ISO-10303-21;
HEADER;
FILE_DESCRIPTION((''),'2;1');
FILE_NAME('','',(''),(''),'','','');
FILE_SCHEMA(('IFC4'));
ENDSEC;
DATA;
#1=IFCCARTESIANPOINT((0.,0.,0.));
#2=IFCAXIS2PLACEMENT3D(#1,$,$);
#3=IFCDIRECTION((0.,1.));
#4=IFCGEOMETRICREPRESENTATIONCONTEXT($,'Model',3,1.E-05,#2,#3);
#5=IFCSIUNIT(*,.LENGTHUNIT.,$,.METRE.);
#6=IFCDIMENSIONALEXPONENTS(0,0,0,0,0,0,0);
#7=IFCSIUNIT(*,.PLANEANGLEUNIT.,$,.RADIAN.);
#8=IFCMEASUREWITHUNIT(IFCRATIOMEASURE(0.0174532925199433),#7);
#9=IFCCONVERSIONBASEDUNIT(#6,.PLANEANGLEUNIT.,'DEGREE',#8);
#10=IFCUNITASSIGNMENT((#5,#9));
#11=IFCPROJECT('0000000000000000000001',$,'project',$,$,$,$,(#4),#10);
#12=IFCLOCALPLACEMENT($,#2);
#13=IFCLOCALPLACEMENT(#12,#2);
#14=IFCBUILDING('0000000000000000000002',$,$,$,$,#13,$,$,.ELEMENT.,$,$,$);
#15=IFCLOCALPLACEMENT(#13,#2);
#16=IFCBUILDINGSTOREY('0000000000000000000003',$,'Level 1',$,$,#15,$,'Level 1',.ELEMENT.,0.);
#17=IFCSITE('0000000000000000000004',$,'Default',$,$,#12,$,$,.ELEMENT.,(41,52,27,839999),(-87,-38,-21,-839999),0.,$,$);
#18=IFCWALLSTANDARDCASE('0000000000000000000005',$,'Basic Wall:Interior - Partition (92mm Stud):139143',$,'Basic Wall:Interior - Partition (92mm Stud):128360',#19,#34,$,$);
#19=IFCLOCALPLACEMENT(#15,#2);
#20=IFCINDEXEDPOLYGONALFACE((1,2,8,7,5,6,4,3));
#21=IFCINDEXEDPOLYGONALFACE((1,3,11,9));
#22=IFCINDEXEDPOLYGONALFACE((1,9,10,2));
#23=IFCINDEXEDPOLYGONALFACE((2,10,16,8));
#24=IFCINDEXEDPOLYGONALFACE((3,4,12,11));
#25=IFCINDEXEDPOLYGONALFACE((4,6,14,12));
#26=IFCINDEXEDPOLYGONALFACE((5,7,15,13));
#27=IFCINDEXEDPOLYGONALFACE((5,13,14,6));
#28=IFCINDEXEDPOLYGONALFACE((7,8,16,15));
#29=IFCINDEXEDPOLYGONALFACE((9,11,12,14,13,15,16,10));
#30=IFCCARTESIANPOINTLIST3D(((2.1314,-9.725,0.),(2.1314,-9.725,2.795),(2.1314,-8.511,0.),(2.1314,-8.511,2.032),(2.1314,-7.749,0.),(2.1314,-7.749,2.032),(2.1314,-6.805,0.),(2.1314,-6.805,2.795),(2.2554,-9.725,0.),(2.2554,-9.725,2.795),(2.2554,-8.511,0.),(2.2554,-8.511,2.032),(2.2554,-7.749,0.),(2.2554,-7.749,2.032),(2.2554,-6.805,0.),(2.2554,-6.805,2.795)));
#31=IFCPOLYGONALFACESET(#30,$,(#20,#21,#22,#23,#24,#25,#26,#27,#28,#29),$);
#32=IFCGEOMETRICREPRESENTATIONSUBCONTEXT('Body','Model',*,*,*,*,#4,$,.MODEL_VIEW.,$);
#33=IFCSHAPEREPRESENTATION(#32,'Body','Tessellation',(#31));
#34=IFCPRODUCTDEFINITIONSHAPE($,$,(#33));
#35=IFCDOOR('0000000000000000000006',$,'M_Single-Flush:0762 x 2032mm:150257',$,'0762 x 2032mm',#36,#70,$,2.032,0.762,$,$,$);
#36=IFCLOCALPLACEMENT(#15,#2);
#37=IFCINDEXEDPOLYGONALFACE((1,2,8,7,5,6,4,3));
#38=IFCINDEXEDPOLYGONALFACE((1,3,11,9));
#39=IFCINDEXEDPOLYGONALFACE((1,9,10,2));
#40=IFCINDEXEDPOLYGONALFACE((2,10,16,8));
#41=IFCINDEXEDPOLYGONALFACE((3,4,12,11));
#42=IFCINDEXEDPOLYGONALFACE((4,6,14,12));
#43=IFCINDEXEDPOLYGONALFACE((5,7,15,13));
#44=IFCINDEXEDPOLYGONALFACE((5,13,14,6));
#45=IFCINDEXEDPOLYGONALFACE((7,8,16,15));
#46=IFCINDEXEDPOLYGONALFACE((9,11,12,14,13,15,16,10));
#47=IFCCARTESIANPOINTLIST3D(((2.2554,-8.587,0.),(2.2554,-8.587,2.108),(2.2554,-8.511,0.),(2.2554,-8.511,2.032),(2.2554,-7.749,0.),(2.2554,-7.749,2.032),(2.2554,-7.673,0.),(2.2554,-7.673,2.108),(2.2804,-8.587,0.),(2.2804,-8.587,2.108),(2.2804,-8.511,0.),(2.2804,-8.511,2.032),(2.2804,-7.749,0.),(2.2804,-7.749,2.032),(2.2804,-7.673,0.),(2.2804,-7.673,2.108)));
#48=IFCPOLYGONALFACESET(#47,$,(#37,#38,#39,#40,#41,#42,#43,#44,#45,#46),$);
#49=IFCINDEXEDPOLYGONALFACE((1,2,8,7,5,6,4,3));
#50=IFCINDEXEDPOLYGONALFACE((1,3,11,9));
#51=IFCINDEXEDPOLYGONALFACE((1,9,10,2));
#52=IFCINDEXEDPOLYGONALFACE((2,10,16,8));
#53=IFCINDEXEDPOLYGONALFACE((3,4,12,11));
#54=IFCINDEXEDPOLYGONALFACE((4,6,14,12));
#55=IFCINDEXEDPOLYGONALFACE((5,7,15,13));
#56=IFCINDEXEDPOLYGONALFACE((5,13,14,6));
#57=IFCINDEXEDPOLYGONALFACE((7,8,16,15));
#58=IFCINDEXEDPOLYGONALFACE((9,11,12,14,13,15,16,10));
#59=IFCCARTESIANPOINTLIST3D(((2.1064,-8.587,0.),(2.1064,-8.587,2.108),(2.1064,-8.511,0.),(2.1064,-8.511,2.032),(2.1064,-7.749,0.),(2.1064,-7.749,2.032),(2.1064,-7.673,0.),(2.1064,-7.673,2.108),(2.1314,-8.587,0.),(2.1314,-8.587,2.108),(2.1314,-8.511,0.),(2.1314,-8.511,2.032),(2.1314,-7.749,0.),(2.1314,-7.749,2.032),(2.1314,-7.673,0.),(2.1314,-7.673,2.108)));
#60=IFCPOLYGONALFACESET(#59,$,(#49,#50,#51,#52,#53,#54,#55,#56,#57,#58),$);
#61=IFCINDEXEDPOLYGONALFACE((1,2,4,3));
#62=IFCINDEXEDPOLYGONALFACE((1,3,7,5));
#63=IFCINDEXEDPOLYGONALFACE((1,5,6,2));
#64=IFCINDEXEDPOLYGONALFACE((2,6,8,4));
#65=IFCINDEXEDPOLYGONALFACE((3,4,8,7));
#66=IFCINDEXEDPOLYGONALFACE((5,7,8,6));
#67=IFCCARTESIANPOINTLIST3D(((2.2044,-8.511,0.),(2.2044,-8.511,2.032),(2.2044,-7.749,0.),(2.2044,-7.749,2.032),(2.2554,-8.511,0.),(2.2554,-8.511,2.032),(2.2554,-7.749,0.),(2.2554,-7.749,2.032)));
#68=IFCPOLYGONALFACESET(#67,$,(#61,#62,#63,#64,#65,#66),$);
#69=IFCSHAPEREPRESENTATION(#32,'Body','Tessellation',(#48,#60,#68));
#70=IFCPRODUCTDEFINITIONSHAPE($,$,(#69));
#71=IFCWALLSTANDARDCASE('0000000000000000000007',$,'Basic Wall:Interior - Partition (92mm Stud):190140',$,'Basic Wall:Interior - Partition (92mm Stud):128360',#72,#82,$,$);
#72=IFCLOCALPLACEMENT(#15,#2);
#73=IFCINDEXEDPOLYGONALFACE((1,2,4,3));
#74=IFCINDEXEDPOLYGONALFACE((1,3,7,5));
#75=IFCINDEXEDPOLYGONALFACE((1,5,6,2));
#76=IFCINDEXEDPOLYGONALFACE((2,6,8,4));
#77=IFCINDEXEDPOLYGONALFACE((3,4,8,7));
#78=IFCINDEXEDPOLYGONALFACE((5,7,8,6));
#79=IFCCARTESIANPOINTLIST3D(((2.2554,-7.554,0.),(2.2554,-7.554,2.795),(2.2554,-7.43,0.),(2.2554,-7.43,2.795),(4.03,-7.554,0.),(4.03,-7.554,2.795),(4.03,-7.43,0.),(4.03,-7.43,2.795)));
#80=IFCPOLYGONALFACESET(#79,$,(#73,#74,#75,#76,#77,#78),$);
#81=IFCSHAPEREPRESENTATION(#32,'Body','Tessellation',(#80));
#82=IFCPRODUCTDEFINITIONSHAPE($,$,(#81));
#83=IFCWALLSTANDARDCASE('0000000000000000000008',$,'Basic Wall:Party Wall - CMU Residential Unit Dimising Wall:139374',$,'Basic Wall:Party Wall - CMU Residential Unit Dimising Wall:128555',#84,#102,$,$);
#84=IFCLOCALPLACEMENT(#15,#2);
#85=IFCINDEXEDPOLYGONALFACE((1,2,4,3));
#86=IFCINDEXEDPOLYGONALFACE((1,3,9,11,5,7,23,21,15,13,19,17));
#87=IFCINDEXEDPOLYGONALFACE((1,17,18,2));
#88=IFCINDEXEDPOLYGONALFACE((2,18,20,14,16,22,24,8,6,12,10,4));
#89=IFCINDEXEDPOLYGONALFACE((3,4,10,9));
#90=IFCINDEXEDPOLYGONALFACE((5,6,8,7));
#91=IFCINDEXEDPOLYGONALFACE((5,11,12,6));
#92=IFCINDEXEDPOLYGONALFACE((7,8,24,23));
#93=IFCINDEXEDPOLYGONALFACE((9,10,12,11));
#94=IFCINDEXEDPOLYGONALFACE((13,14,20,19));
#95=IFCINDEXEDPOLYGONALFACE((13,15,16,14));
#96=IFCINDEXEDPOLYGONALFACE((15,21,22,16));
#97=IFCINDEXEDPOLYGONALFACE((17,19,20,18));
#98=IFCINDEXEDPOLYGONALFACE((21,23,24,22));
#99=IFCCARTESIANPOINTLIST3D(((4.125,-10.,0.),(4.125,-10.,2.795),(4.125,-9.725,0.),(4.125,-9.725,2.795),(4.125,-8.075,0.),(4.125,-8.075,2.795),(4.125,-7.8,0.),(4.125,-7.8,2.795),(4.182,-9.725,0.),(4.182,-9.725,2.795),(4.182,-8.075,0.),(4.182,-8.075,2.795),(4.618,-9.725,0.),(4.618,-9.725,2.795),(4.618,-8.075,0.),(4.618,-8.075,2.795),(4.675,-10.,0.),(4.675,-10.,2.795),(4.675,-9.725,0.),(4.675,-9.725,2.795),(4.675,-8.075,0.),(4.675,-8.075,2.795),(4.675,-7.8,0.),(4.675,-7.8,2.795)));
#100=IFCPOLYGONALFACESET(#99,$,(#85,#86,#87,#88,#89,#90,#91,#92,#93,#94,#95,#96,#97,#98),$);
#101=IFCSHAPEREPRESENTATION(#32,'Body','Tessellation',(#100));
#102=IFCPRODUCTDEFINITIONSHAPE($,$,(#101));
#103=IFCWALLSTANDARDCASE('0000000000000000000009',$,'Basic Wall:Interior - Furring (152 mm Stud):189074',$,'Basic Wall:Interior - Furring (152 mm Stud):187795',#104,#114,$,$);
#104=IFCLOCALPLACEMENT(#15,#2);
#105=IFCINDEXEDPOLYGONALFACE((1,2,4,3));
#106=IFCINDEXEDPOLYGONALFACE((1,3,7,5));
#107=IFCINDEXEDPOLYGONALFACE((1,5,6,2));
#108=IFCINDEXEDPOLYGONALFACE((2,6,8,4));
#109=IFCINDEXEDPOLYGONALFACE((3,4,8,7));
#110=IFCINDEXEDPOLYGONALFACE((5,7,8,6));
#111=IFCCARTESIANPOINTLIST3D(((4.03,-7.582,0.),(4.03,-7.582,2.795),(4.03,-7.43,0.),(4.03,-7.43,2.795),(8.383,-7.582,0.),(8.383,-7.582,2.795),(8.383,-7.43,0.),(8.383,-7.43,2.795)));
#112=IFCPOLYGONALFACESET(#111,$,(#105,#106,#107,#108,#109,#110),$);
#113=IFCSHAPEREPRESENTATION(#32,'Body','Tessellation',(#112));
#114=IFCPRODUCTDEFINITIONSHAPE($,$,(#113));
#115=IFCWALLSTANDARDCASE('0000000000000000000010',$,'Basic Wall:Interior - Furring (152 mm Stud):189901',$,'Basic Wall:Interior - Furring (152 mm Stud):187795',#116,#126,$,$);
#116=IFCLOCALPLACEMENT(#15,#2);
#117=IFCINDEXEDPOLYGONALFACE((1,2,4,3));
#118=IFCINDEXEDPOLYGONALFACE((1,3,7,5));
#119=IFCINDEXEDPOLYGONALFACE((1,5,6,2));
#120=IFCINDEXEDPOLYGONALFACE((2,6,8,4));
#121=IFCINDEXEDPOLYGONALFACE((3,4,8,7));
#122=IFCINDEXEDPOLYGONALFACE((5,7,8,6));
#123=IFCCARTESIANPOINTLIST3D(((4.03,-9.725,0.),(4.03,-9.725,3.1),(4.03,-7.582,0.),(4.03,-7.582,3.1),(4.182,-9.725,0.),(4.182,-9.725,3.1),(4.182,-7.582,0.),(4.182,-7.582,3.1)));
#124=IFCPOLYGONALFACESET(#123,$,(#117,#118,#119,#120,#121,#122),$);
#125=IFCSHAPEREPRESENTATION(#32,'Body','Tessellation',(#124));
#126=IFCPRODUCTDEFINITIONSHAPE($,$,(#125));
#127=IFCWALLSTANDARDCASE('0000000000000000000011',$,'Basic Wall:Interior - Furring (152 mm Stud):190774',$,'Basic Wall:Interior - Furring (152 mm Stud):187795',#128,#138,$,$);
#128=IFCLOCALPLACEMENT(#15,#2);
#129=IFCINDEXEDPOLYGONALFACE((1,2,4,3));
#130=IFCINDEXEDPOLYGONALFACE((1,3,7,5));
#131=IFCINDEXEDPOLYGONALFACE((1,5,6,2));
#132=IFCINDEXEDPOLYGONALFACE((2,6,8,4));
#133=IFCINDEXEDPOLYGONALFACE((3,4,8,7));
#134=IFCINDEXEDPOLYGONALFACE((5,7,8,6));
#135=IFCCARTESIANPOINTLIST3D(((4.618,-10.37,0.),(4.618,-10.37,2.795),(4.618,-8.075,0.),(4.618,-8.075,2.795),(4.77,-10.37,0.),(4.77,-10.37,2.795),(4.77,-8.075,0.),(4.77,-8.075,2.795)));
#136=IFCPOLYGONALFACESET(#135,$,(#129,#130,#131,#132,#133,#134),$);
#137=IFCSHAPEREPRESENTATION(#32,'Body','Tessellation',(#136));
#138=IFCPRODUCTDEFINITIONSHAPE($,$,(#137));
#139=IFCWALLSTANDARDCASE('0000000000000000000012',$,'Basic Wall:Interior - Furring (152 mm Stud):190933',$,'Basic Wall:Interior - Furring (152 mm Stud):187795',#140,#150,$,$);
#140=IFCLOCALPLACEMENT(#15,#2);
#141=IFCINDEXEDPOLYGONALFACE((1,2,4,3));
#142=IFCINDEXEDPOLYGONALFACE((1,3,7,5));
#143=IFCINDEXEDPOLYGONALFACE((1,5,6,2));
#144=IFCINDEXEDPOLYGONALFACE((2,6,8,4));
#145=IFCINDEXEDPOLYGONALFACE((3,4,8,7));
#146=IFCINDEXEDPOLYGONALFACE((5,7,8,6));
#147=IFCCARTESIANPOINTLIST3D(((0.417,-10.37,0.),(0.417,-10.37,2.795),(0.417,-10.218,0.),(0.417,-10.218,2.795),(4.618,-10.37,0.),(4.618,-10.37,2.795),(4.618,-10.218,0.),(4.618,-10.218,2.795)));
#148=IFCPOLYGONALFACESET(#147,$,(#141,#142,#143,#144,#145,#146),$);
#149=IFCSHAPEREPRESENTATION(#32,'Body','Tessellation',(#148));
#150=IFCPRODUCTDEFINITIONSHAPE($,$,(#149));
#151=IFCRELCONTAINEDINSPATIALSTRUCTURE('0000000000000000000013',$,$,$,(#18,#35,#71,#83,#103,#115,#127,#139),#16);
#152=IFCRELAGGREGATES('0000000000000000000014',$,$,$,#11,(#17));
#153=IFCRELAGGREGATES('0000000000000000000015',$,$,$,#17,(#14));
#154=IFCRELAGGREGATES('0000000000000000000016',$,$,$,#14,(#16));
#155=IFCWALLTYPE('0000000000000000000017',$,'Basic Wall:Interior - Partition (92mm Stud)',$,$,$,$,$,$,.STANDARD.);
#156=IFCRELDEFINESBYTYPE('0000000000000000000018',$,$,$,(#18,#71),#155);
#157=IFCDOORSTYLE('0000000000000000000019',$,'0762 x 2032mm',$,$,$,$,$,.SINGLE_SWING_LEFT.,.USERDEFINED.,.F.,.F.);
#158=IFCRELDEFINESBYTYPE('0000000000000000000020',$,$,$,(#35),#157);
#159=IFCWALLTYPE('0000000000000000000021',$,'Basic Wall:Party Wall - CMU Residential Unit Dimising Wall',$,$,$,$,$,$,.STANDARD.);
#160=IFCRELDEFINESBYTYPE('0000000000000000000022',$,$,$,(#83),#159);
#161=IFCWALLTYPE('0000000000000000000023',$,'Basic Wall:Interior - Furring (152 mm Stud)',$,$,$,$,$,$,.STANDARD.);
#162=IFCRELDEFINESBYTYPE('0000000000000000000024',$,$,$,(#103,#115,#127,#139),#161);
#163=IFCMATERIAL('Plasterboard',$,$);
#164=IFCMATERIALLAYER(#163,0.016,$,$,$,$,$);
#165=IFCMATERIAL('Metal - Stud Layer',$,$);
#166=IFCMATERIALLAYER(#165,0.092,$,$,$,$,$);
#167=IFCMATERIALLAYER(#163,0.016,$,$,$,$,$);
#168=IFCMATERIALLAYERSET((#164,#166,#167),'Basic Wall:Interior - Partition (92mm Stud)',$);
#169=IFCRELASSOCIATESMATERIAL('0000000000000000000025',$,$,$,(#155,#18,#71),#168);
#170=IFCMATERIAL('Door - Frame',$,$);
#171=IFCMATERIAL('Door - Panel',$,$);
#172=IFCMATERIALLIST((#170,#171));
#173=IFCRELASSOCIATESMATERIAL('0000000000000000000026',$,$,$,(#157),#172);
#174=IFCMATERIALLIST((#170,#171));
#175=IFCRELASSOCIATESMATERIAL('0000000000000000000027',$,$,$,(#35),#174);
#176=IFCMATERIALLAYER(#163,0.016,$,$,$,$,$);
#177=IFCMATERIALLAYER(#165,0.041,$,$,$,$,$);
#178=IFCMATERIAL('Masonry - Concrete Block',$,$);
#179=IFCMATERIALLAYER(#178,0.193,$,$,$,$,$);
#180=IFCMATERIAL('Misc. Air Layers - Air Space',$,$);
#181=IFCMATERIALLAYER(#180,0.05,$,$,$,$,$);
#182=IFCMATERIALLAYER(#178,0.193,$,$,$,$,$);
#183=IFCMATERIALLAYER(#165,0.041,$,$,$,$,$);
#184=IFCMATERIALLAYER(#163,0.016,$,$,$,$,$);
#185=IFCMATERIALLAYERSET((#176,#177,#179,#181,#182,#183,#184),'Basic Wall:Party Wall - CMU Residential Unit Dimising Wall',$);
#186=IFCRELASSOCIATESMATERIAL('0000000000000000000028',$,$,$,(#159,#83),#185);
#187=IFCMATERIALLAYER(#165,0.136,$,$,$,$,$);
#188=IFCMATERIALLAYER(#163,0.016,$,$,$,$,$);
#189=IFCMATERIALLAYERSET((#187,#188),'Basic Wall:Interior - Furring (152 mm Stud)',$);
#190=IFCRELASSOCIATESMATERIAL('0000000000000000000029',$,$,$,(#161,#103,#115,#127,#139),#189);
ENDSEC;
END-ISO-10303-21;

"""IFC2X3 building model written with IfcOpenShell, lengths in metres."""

from ifc_helpers import new_model, entity, si_unit, converted_unit, direction, frame, frame_2d, origin, place, context, subcontext, project, spatial, polyline, rectangle, outline, extrude, clip, bounded_halfspace, source, transform, mapped, material, material_list, layer, layer_set, layer_usage, type_object, type_shapes, element, fill, save


model = new_model("IFC2X3")

# Units and contexts
model_context = context("Model", 3, precision=1e-05, world=origin(), true_north=direction((0.0, 1.0)))
body_context = subcontext(model_context, "Body", "Model", "MODEL_VIEW")
ifc_project = project(units=[si_unit("LENGTHUNIT", "METRE"), converted_unit("PLANEANGLEUNIT", "DEGREE", entity("IfcRatioMeasure", 0.0174532925199433), si_unit("PLANEANGLEUNIT", "RADIAN"), dimensions=[0, 0, 0, 0, 0, 0, 0])], contexts=[model_context])

# Site, building, storey
site_placement = place(None, origin())
site = spatial("IfcSite", under=ifc_project, at=site_placement, Name="Default", CompositionType="ELEMENT", RefLatitude=(41, 52, 27, 839999), RefLongitude=(-87, -38, -21, -839999), RefElevation=0.0)
building_placement = place(site_placement, origin())
building = spatial("IfcBuilding", under=site, at=building_placement, CompositionType="ELEMENT")
storey_placement = place(building_placement, origin())
storey = spatial("IfcBuildingStorey", under=building, at=storey_placement, Name="Level 1", LongName="Level 1", CompositionType="ELEMENT", Elevation=0.0)

# Wall, opening, door
ifc_material_1 = material(Name="Plasterboard")
ifc_layer_1 = layer(ifc_material_1, 0.016)
ifc_material_2 = material(Name="Metal - Stud Layer")
ifc_layer_2 = layer(ifc_material_2, 0.092)
ifc_layer_3 = layer(ifc_material_1, 0.016)
ifc_layer_set_1 = layer_set([ifc_layer_1, ifc_layer_2, ifc_layer_3], Name="Basic Wall:Interior - Partition (92mm Stud)")
ifc_layer_usage_1 = layer_usage(ifc_layer_set_1, "AXIS2", "NEGATIVE", 0.062)
wall_type_1 = type_object("IfcWallType", Name="Basic Wall:Interior - Partition (92mm Stud)", PredefinedType="STANDARD", material=ifc_layer_set_1)
wall_1_placement = place(storey_placement, frame((2.1934, -6.805, 0.0), z_axis=(0.0, 0.0, 1.0), x_axis=(0.0, -1.0, 0.0)))
wall_1 = element("IfcWallStandardCase", 1, at=wall_1_placement, inside=storey, type_object=wall_type_1, material=ifc_layer_usage_1, Name="Basic Wall:Interior - Partition (92mm Stud):139143", ObjectType="Basic Wall:Interior - Partition (92mm Stud):128360", context=body_context, shape_type="SweptSolid", body=[
    extrude(rectangle(XDim=2.92, YDim=0.124, at=frame_2d((1.46, 0.0), x_axis=(-1.0, 0.0))), origin(), (0.0, 0.0, 1.0), 2.795),
])
opening_1_placement = place(wall_1_placement, frame((0.944, -0.062, 0.0)))
opening_1 = element("IfcOpeningElement", 2, at=opening_1_placement, cuts=wall_1, ObjectType="Opening", context=body_context, shape_type="SweptSolid", body=[
    extrude(rectangle(XDim=0.762, YDim=2.032, at=frame_2d((1.016, 0.381), x_axis=(0.0, -1.0))), frame((0.0, 0.0, 0.0), z_axis=(0.0, 1.0, 0.0), x_axis=(0.0, 0.0, 1.0)), (0.0, 0.0, 1.0), 0.124),
])
ifc_material_3 = material(Name="Door - Frame")
ifc_material_4 = material(Name="Door - Panel")
ifc_material_list_1 = material_list([ifc_material_3, ifc_material_4])
ifc_material_list_2 = material_list([ifc_material_3, ifc_material_4])
door_style = type_object("IfcDoorStyle", Name="0762 x 2032mm", ConstructionType="USERDEFINED", OperationType="SINGLE_SWING_LEFT", ParameterTakesPrecedence=False, Sizeable=False, material=ifc_material_list_2)
shared_shape_1 = source(origin(), body_context, "Body", "SweptSolid", [
    extrude(outline(polyline([(-0.457, -1.073), (0.457, -1.073), (0.457, 1.035), (0.381, 1.035), (0.381, -0.997), (-0.381, -0.997), (-0.381, 1.035), (-0.457, 1.035), (-0.457, -1.073)])), frame((0.381, 0.149, 1.035), z_axis=(0.0, -1.0, 0.0), x_axis=(-1.0, 0.0, 0.0)), (0.0, 0.0, 1.0), 0.025),
    extrude(outline(polyline([(-1.073, -0.457), (1.035, -0.457), (1.035, -0.381), (-0.997, -0.381), (-0.997, 0.381), (1.035, 0.381), (1.035, 0.457), (-1.073, 0.457), (-1.073, -0.457)])), frame((0.381, 0.0, 1.035), z_axis=(0.0, -1.0, 0.0), x_axis=(0.0, 0.0, -1.0)), (0.0, 0.0, 1.0), 0.025),
    extrude(rectangle(XDim=0.762, YDim=0.051, at=frame_2d((0.0, 0.0), x_axis=(1.0, 0.0))), frame((0.381, 0.0985, 0.0)), (0.0, 0.0, 1.0), 2.032),
])
type_shapes(door_style, [shared_shape_1])
door_placement = place(opening_1_placement, origin())
door = element("IfcDoor", 3, at=door_placement, inside=storey, type_object=door_style, material=ifc_material_list_1, Name="M_Single-Flush:0762 x 2032mm:150257", ObjectType="0762 x 2032mm", OverallHeight=2.032, OverallWidth=0.762, context=body_context, shape_type="MappedRepresentation", body=[
    mapped(shared_shape_1, transform((0.0, 0.0, 0.0), scale=1.0)),
])
fill(opening_1, door)

# Walls
ifc_layer_usage_2 = layer_usage(ifc_layer_set_1, "AXIS2", "NEGATIVE", 0.062)
wall_2_placement = place(storey_placement, frame((4.03, -7.492, 0.0), z_axis=(0.0, 0.0, 1.0), x_axis=(-1.0, 0.0, 0.0)))
element("IfcWallStandardCase", 4, at=wall_2_placement, inside=storey, type_object=wall_type_1, material=ifc_layer_usage_2, Name="Basic Wall:Interior - Partition (92mm Stud):190140", ObjectType="Basic Wall:Interior - Partition (92mm Stud):128360", context=body_context, shape_type="SweptSolid", body=[
    extrude(rectangle(XDim=1.7746, YDim=0.124, at=frame_2d((0.8873, 0.0), x_axis=(-1.0, 0.0))), origin(), (0.0, 0.0, 1.0), 2.795),
])
ifc_material_5 = material(Name="Masonry - Concrete Block")
ifc_material_6 = material(Name="Misc. Air Layers - Air Space")
ifc_layer_4 = layer(ifc_material_1, 0.016)
ifc_layer_5 = layer(ifc_material_2, 0.041)
ifc_layer_6 = layer(ifc_material_5, 0.193)
ifc_layer_7 = layer(ifc_material_6, 0.05)
ifc_layer_8 = layer(ifc_material_5, 0.193)
ifc_layer_9 = layer(ifc_material_2, 0.041)
ifc_layer_10 = layer(ifc_material_1, 0.016)
ifc_layer_set_2 = layer_set([ifc_layer_4, ifc_layer_5, ifc_layer_6, ifc_layer_7, ifc_layer_8, ifc_layer_9, ifc_layer_10], Name="Basic Wall:Party Wall - CMU Residential Unit Dimising Wall")
wall_type_2 = type_object("IfcWallType", Name="Basic Wall:Party Wall - CMU Residential Unit Dimising Wall", PredefinedType="STANDARD", material=ifc_layer_set_2)
ifc_layer_usage_3 = layer_usage(ifc_layer_set_2, "AXIS2", "NEGATIVE", 0.275)
wall_3_placement = place(storey_placement, frame((4.4, -10.0, 0.0), z_axis=(0.0, 0.0, 1.0), x_axis=(0.0, 1.0, 0.0)))
element("IfcWallStandardCase", 5, at=wall_3_placement, inside=storey, type_object=wall_type_2, material=ifc_layer_usage_3, Name="Basic Wall:Party Wall - CMU Residential Unit Dimising Wall:139374", ObjectType="Basic Wall:Party Wall - CMU Residential Unit Dimising Wall:128555", context=body_context, shape_type="Clipping", body=[
    clip(clip(extrude(rectangle(XDim=2.2, YDim=0.55, at=frame_2d((1.1, 0.0), x_axis=(-1.0, 0.0))), origin(), (0.0, 0.0, 1.0), 2.795), bounded_halfspace(frame((1.925, 0.218, 0.0), z_axis=(0.0, -1.0, 0.0), x_axis=(1.0, 0.0, 0.0)), True, frame((1.925, 0.218, 0.0), z_axis=(0.0, -1.0, 0.0), x_axis=(1.0, 0.0, 0.0)), polyline([(0.0, 0.0), (0.0, 2.795), (-1.65, 2.795), (-1.65, 0.0), (0.0, 0.0)]))), bounded_halfspace(frame((0.275, -0.218, 0.0), z_axis=(0.0, 1.0, 0.0), x_axis=(-1.0, 0.0, 0.0)), True, frame((0.275, -0.218, 0.0), z_axis=(0.0, 1.0, 0.0), x_axis=(-1.0, 0.0, 0.0)), polyline([(0.0, 0.0), (0.0, 2.795), (-1.65, 2.795), (-1.65, 0.0), (0.0, 0.0)]))),
])
ifc_layer_11 = layer(ifc_material_2, 0.136)
ifc_layer_12 = layer(ifc_material_1, 0.016)
ifc_layer_set_3 = layer_set([ifc_layer_11, ifc_layer_12], Name="Basic Wall:Interior - Furring (152 mm Stud)")
ifc_layer_usage_4 = layer_usage(ifc_layer_set_3, "AXIS2", "NEGATIVE", 0.076)
wall_type_3 = type_object("IfcWallType", Name="Basic Wall:Interior - Furring (152 mm Stud)", PredefinedType="STANDARD", material=ifc_layer_set_3)
wall_4_placement = place(storey_placement, frame((8.383, -7.506, 0.0), z_axis=(0.0, 0.0, 1.0), x_axis=(-1.0, 0.0, 0.0)))
element("IfcWallStandardCase", 6, at=wall_4_placement, inside=storey, type_object=wall_type_3, material=ifc_layer_usage_4, Name="Basic Wall:Interior - Furring (152 mm Stud):189074", ObjectType="Basic Wall:Interior - Furring (152 mm Stud):187795", context=body_context, shape_type="Clipping", body=[
    clip(extrude(rectangle(XDim=4.353, YDim=0.152, at=frame_2d((2.1765, 0.0), x_axis=(-1.0, 0.0))), origin(), (0.0, 0.0, 1.0), 2.795), bounded_halfspace(frame((0.0, -0.076, 2.795), z_axis=(0.0, 0.0, -1.0), x_axis=(0.0, 1.0, 0.0)), True, frame((0.0, -0.076, 2.795)), polyline([(0.0, 0.0), (3.708, 0.0), (3.708, 0.152), (0.0, 0.152), (0.0, 0.0)]))),
])
ifc_layer_usage_5 = layer_usage(ifc_layer_set_3, "AXIS2", "POSITIVE", -0.076)
wall_5_placement = place(storey_placement, frame((4.106, -9.725, 0.0), z_axis=(0.0, 0.0, 1.0), x_axis=(0.0, 1.0, 0.0)))
element("IfcWallStandardCase", 7, at=wall_5_placement, inside=storey, type_object=wall_type_3, material=ifc_layer_usage_5, Name="Basic Wall:Interior - Furring (152 mm Stud):189901", ObjectType="Basic Wall:Interior - Furring (152 mm Stud):187795", context=body_context, shape_type="SweptSolid", body=[
    extrude(rectangle(XDim=2.143, YDim=0.152, at=frame_2d((1.0715, 0.0), x_axis=(-1.0, 0.0))), origin(), (0.0, 0.0, 1.0), 3.1),
])
ifc_layer_usage_6 = layer_usage(ifc_layer_set_3, "AXIS2", "POSITIVE", -0.076)
wall_6_placement = place(storey_placement, frame((4.694, -8.075, 0.0), z_axis=(0.0, 0.0, 1.0), x_axis=(0.0, -1.0, 0.0)))
element("IfcWallStandardCase", 8, at=wall_6_placement, inside=storey, type_object=wall_type_3, material=ifc_layer_usage_6, Name="Basic Wall:Interior - Furring (152 mm Stud):190774", ObjectType="Basic Wall:Interior - Furring (152 mm Stud):187795", context=body_context, shape_type="SweptSolid", body=[
    extrude(rectangle(XDim=2.295, YDim=0.152, at=frame_2d((1.1475, 0.0), x_axis=(-1.0, 0.0))), origin(), (0.0, 0.0, 1.0), 2.795),
])
ifc_layer_usage_7 = layer_usage(ifc_layer_set_3, "AXIS2", "NEGATIVE", 0.076)
wall_7_placement = place(storey_placement, frame((0.417, -10.294, 0.0)))
element("IfcWallStandardCase", 9, at=wall_7_placement, inside=storey, type_object=wall_type_3, material=ifc_layer_usage_7, Name="Basic Wall:Interior - Furring (152 mm Stud):190933", ObjectType="Basic Wall:Interior - Furring (152 mm Stud):187795", context=body_context, shape_type="SweptSolid", body=[
    extrude(rectangle(XDim=4.201, YDim=0.152, at=frame_2d((2.1005, 0.0), x_axis=(-1.0, 0.0))), origin(), (0.0, 0.0, 1.0), 2.795),
])

save(model, "model.ifc")
